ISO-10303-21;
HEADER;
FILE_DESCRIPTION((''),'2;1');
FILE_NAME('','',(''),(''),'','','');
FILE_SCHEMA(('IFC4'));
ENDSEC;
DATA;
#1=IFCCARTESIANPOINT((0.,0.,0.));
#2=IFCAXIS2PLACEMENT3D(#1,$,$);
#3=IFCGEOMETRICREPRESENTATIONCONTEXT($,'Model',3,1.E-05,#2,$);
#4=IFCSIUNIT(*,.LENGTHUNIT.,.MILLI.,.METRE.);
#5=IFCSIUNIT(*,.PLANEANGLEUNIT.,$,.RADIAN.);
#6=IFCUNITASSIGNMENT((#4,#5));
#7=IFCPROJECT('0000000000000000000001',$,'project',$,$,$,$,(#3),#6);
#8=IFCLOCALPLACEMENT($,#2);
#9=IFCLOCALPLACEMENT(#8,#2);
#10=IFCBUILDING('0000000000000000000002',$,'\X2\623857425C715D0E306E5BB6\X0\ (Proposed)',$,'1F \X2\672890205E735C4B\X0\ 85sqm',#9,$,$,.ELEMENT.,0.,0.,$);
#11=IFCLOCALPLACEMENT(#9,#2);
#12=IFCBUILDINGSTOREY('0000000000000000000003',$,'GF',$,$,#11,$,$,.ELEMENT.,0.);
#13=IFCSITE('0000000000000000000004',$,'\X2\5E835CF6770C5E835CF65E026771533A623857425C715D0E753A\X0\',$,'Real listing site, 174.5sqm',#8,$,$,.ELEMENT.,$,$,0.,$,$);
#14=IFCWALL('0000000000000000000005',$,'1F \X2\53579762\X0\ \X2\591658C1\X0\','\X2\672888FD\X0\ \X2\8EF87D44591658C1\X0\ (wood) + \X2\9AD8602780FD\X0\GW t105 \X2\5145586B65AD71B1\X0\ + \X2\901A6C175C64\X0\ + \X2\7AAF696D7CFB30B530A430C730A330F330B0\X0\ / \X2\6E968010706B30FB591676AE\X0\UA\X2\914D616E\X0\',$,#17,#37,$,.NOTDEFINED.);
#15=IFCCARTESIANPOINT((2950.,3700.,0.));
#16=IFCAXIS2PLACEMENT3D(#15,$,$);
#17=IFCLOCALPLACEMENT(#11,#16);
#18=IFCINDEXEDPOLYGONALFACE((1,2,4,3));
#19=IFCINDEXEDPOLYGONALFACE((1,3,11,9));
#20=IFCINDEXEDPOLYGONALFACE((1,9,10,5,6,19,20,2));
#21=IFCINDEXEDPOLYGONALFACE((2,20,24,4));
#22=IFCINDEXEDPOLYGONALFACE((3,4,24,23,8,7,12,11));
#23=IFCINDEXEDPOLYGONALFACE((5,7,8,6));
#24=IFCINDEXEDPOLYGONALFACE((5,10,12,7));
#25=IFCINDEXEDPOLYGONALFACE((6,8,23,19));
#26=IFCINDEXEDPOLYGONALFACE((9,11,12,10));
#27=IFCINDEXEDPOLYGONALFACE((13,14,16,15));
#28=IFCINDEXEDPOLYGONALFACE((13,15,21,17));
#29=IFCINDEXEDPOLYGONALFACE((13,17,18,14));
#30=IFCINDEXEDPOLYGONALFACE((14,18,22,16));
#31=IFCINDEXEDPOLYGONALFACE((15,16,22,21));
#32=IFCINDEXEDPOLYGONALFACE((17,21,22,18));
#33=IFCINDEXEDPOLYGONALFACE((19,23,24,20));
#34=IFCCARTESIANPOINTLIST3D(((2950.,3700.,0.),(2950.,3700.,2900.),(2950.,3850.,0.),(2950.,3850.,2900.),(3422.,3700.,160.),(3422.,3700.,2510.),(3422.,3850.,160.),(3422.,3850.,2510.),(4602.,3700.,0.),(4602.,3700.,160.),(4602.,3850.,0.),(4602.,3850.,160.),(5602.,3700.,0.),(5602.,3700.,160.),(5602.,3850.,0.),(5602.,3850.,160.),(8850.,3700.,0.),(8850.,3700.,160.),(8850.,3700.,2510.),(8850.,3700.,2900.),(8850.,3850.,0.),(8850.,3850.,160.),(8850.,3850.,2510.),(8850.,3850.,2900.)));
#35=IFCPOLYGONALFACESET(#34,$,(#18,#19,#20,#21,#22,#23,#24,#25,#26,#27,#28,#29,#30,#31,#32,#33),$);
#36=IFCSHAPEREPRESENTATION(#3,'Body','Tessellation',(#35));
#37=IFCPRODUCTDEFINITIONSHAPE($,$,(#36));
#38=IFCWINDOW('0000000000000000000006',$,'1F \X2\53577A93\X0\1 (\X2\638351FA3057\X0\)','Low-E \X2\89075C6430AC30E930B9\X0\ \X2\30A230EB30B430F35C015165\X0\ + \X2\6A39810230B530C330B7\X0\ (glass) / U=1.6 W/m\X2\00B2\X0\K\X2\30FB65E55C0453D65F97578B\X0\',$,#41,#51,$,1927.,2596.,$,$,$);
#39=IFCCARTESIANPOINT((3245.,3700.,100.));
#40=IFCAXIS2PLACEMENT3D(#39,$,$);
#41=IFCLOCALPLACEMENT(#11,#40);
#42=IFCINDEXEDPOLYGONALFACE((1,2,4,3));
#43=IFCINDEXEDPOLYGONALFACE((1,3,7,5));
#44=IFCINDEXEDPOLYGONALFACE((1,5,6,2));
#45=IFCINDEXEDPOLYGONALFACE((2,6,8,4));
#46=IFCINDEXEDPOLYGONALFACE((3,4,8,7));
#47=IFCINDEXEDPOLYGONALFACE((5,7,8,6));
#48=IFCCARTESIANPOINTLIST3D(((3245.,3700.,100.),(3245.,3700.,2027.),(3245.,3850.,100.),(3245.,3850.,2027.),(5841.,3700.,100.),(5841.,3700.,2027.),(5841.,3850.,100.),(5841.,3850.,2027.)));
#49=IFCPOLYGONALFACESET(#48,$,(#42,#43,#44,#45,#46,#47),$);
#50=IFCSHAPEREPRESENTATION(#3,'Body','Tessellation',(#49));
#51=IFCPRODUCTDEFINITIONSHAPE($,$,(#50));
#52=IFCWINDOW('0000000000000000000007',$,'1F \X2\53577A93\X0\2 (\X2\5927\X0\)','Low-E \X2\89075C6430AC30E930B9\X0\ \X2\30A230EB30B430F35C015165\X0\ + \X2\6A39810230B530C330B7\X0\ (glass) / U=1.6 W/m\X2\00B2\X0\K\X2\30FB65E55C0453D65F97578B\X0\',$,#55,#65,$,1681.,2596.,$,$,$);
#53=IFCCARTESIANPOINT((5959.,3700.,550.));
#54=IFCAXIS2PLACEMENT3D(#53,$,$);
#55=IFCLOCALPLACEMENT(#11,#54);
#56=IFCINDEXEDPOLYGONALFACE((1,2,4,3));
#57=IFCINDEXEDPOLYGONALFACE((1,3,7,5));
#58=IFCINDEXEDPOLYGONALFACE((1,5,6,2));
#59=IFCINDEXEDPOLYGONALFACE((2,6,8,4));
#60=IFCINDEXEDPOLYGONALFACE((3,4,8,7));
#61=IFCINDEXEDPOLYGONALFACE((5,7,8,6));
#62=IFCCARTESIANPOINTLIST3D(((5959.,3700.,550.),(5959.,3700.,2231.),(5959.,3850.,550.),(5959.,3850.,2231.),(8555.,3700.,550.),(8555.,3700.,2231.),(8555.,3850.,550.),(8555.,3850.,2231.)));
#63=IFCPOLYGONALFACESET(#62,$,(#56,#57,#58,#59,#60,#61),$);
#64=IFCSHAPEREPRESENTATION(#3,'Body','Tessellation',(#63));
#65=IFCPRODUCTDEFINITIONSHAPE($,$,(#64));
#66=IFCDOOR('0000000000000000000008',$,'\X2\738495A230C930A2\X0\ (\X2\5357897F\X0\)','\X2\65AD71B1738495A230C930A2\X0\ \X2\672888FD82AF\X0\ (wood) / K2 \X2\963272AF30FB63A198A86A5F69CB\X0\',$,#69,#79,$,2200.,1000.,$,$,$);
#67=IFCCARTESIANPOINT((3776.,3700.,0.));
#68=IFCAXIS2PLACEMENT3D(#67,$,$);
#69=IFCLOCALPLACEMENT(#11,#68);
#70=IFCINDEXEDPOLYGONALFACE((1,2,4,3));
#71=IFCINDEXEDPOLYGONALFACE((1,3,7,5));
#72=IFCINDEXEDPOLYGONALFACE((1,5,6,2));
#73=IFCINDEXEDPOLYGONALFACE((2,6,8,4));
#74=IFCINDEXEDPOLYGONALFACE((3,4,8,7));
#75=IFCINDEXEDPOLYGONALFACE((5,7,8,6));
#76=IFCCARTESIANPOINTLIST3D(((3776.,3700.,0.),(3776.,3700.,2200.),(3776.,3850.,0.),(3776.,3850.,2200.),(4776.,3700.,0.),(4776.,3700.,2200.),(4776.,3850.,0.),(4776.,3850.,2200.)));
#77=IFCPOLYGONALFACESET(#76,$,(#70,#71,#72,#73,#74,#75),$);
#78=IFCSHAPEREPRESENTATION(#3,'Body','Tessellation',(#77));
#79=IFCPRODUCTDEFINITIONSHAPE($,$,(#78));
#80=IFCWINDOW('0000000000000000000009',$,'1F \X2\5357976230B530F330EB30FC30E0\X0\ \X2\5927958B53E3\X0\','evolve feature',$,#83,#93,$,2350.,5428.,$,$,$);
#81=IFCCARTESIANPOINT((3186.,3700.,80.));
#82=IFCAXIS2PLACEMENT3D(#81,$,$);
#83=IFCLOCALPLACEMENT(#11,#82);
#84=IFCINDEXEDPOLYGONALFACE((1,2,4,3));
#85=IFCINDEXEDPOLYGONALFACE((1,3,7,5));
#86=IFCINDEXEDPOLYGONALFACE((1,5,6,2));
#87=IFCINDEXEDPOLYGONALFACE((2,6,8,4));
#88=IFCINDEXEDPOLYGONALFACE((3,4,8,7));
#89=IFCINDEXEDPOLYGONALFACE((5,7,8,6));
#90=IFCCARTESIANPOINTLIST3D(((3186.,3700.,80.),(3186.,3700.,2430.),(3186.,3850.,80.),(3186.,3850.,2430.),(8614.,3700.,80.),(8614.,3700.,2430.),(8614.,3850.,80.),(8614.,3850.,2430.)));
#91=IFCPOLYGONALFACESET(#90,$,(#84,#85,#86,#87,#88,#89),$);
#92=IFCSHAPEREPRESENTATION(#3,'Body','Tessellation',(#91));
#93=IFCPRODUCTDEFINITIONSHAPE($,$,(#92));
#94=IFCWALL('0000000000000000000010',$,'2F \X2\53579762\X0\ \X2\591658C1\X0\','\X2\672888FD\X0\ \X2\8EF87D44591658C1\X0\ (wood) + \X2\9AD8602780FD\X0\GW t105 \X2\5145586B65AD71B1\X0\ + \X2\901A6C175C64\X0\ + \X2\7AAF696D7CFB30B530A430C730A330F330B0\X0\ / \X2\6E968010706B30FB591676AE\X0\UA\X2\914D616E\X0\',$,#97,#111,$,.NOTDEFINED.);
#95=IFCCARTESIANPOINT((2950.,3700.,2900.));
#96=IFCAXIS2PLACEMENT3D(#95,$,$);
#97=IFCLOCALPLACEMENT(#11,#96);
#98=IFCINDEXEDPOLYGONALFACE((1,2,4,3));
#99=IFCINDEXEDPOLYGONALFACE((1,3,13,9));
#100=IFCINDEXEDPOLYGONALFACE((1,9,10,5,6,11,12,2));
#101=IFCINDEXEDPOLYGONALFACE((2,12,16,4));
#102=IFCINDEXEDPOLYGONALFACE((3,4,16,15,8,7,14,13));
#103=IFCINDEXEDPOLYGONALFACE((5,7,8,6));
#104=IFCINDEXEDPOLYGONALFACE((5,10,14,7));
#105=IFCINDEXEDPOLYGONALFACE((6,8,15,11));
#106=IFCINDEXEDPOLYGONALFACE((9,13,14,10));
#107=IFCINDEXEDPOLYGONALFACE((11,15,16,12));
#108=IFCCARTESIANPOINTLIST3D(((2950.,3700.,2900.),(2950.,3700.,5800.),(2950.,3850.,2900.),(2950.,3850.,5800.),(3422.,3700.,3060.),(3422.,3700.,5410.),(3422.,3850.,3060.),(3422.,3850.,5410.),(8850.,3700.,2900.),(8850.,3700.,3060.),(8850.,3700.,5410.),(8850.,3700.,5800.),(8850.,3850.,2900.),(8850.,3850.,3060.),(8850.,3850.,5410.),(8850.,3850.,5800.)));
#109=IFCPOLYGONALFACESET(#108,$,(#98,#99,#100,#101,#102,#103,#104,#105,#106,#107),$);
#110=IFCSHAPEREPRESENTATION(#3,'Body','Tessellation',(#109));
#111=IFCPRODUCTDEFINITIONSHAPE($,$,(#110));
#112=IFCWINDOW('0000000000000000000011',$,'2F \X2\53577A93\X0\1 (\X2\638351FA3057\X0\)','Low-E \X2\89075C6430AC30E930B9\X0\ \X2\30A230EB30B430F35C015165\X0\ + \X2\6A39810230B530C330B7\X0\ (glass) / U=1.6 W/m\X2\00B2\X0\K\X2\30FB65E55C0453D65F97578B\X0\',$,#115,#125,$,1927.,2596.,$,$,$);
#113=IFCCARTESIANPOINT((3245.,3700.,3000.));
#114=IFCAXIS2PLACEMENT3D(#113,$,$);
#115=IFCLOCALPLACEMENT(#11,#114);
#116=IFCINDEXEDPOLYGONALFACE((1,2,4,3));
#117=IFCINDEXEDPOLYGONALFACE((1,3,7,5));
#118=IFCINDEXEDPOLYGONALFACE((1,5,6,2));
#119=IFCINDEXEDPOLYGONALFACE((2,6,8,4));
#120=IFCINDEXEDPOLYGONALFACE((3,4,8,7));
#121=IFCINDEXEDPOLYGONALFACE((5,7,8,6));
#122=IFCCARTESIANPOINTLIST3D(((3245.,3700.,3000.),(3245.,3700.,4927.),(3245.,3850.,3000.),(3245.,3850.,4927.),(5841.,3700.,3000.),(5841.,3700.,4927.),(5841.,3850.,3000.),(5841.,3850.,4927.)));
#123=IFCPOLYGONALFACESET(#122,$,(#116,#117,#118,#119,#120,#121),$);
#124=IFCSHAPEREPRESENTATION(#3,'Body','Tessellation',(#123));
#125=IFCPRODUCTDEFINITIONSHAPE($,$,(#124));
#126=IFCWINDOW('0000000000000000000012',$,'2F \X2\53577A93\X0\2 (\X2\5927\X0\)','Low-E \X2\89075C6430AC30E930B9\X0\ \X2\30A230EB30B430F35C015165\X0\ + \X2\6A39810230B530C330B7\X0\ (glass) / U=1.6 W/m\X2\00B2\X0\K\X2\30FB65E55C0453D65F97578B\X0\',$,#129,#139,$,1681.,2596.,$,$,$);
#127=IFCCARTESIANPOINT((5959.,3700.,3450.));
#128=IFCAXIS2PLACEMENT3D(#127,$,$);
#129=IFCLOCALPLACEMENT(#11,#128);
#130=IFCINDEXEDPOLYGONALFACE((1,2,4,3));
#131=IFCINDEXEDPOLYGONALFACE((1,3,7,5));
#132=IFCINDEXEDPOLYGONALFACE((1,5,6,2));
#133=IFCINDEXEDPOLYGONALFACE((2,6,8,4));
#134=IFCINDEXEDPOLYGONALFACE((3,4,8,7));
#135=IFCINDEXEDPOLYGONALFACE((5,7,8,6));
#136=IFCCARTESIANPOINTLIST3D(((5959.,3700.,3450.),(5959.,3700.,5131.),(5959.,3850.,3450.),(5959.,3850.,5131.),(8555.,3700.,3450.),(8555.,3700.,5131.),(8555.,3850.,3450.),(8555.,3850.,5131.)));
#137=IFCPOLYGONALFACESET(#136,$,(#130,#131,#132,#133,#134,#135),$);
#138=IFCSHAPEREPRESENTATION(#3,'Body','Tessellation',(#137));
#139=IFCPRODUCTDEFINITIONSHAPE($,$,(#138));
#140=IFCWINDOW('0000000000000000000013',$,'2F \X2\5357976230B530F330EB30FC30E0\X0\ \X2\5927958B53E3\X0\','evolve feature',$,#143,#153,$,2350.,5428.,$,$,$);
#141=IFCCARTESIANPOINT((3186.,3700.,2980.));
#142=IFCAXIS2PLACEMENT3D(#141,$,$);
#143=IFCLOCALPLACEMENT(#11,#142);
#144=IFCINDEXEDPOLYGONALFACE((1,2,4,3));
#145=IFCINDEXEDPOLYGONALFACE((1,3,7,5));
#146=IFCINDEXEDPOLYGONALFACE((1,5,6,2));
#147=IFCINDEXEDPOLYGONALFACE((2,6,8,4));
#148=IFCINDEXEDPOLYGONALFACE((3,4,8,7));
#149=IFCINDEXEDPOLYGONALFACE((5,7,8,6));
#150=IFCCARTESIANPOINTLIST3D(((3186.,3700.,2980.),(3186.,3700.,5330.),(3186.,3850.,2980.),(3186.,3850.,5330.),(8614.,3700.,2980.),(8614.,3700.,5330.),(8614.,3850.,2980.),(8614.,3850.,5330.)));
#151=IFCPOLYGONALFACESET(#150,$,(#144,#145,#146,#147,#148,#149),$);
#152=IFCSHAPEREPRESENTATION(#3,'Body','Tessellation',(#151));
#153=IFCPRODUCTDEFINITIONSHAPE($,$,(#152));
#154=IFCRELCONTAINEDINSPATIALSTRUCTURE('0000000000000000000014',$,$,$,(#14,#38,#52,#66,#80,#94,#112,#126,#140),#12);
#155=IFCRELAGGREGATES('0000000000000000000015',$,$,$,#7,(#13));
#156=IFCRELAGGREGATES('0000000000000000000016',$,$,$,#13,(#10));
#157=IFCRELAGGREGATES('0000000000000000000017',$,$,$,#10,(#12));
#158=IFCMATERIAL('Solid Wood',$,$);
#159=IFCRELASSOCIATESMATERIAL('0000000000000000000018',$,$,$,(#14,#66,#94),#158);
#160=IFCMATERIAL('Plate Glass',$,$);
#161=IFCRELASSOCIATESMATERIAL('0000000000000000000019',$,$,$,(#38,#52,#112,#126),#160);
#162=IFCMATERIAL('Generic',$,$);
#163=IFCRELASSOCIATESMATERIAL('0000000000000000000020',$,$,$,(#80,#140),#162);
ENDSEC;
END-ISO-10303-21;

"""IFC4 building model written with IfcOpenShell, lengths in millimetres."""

from ifc_helpers import new_model, si_unit, frame, frame_2d, origin, place, context, project, spatial, rectangle, extrude, material, element, fill, save


model = new_model("IFC4")

# Units and contexts
model_context = context("Model", 3, precision=1e-05, world=origin())
ifc_project = project(units=[si_unit("LENGTHUNIT", "METRE", prefix="MILLI"), si_unit("PLANEANGLEUNIT", "RADIAN")], contexts=[model_context])

# Site, building, storey
site_placement = place(None, origin())
site = spatial("IfcSite", under=ifc_project, at=site_placement, Name="広島県広島市東区戸坂山崎町", ObjectType="Real listing site, 174.5sqm", CompositionType="ELEMENT", RefElevation=0.0)
building_placement = place(site_placement, origin())
building = spatial("IfcBuilding", under=site, at=building_placement, Name="戸坂山崎の家 (Proposed)", ObjectType="1F 木造平屋 85sqm", CompositionType="ELEMENT", ElevationOfRefHeight=0.0, ElevationOfTerrain=0.0)
storey_placement = place(building_placement, origin())
storey = spatial("IfcBuildingStorey", under=building, at=storey_placement, Name="GF", CompositionType="ELEMENT", Elevation=0.0)

# Shared definitions
ifc_material_1 = material(Name="Solid Wood")
ifc_material_2 = material(Name="Generic")

# Wall, openings, windows, door
wall_1_placement = place(storey_placement, frame((2950.0, 3700.0, 0.0)))
wall_1 = element("IfcWall", 1, at=wall_1_placement, inside=storey, material=ifc_material_1, Name="1F 南面 外壁", Description="木製 軸組外壁 (wood) + 高性能GW t105 充填断熱 + 通気層 + 窯業系サイディング / 準耐火・外皮UA配慮", PredefinedType="NOTDEFINED", context=model_context, shape_type="SweptSolid", body=[
    extrude(rectangle(XDim=5900.0, YDim=150.0, at=frame_2d((2950.0, 75.0))), frame((2950.0, 3700.0, 0.0)), (0.0, 0.0, 1.0), 2900.0),
])
opening_1_placement = place(storey_placement, frame((3245.0, 3700.0, 100.0)))
opening_1 = element("IfcOpeningElement", 2, at=opening_1_placement, cuts=wall_1, PredefinedType="NOTDEFINED", context=model_context, shape_type="SweptSolid", body=[
    extrude(rectangle(XDim=2596.0, YDim=150.0, at=frame_2d((1298.0, 75.0))), frame((3245.0, 3700.0, 100.0)), (0.0, 0.0, 1.0), 1927.0),
])
opening_2_placement = place(storey_placement, frame((5959.0, 3700.0, 550.0)))
opening_2 = element("IfcOpeningElement", 3, at=opening_2_placement, cuts=wall_1, PredefinedType="NOTDEFINED", context=model_context, shape_type="SweptSolid", body=[
    extrude(rectangle(XDim=2596.0, YDim=150.0, at=frame_2d((1298.0, 75.0))), frame((5959.0, 3700.0, 550.0)), (0.0, 0.0, 1.0), 1681.0),
])
opening_3_placement = place(storey_placement, frame((3776.0, 3700.0, 0.0)))
opening_3 = element("IfcOpeningElement", 4, at=opening_3_placement, cuts=wall_1, PredefinedType="NOTDEFINED", context=model_context, shape_type="SweptSolid", body=[
    extrude(rectangle(XDim=1000.0, YDim=150.0, at=frame_2d((500.0, 75.0))), frame((3776.0, 3700.0, 0.0)), (0.0, 0.0, 1.0), 2200.0),
])
opening_4_placement = place(storey_placement, frame((3186.0, 3700.0, 80.0)))
opening_4 = element("IfcOpeningElement", 5, at=opening_4_placement, cuts=wall_1, PredefinedType="NOTDEFINED", context=model_context, shape_type="SweptSolid", body=[
    extrude(rectangle(XDim=5428.0, YDim=150.0, at=frame_2d((2714.0, 75.0))), frame((3186.0, 3700.0, 80.0)), (0.0, 0.0, 1.0), 2350.0),
])
ifc_material_3 = material(Name="Plate Glass")
window_1_placement = place(storey_placement, frame((3245.0, 3700.0, 100.0)))
window_1 = element("IfcWindow", 6, at=window_1_placement, inside=storey, material=ifc_material_3, Name="1F 南窓1 (掃出し)", Description="Low-E 複層ガラス アルゴン封入 + 樹脂サッシ (glass) / U=1.6 W/m²K・日射取得型", OverallHeight=1927.0, OverallWidth=2596.0, context=model_context, shape_type="SweptSolid", body=[
    extrude(rectangle(XDim=2596.0, YDim=150.0, at=frame_2d((1298.0, 75.0))), frame((3245.0, 3700.0, 100.0)), (0.0, 0.0, 1.0), 1927.0),
])
fill(opening_1, window_1)
window_2_placement = place(storey_placement, frame((5959.0, 3700.0, 550.0)))
window_2 = element("IfcWindow", 7, at=window_2_placement, inside=storey, material=ifc_material_3, Name="1F 南窓2 (大)", Description="Low-E 複層ガラス アルゴン封入 + 樹脂サッシ (glass) / U=1.6 W/m²K・日射取得型", OverallHeight=1681.0, OverallWidth=2596.0, context=model_context, shape_type="SweptSolid", body=[
    extrude(rectangle(XDim=2596.0, YDim=150.0, at=frame_2d((1298.0, 75.0))), frame((5959.0, 3700.0, 550.0)), (0.0, 0.0, 1.0), 1681.0),
])
fill(opening_2, window_2)
door_placement = place(storey_placement, frame((3776.0, 3700.0, 0.0)))
door = element("IfcDoor", 8, at=door_placement, inside=storey, material=ifc_material_1, Name="玄関ドア (南西)", Description="断熱玄関ドア 木製芯 (wood) / K2 防犯・採風機構", OverallHeight=2200.0, OverallWidth=1000.0, context=model_context, shape_type="SweptSolid", body=[
    extrude(rectangle(XDim=1000.0, YDim=150.0, at=frame_2d((500.0, 75.0))), frame((3776.0, 3700.0, 0.0)), (0.0, 0.0, 1.0), 2200.0),
])
fill(opening_3, door)
window_3_placement = place(storey_placement, frame((3186.0, 3700.0, 80.0)))
window_3 = element("IfcWindow", 9, at=window_3_placement, inside=storey, material=ifc_material_2, Name="1F 南面サンルーム 大開口", Description="evolve feature", OverallHeight=2350.0, OverallWidth=5428.0, context=model_context, shape_type="SweptSolid", body=[
    extrude(rectangle(XDim=5428.0, YDim=150.0, at=frame_2d((2714.0, 75.0))), frame((3186.0, 3700.0, 80.0)), (0.0, 0.0, 1.0), 2350.0),
])
fill(opening_4, window_3)

# Wall, openings, windows
wall_2_placement = place(storey_placement, frame((2950.0, 3700.0, 2900.0)))
wall_2 = element("IfcWall", 10, at=wall_2_placement, inside=storey, material=ifc_material_1, Name="2F 南面 外壁", Description="木製 軸組外壁 (wood) + 高性能GW t105 充填断熱 + 通気層 + 窯業系サイディング / 準耐火・外皮UA配慮", PredefinedType="NOTDEFINED", context=model_context, shape_type="SweptSolid", body=[
    extrude(rectangle(XDim=5900.0, YDim=150.0, at=frame_2d((2950.0, 75.0))), frame((2950.0, 3700.0, 2900.0)), (0.0, 0.0, 1.0), 2900.0),
])
opening_5_placement = place(storey_placement, frame((3245.0, 3700.0, 3000.0)))
opening_5 = element("IfcOpeningElement", 11, at=opening_5_placement, cuts=wall_2, PredefinedType="NOTDEFINED", context=model_context, shape_type="SweptSolid", body=[
    extrude(rectangle(XDim=2596.0, YDim=150.0, at=frame_2d((1298.0, 75.0))), frame((3245.0, 3700.0, 3000.0)), (0.0, 0.0, 1.0), 1927.0),
])
opening_6_placement = place(storey_placement, frame((5959.0, 3700.0, 3450.0)))
opening_6 = element("IfcOpeningElement", 12, at=opening_6_placement, cuts=wall_2, PredefinedType="NOTDEFINED", context=model_context, shape_type="SweptSolid", body=[
    extrude(rectangle(XDim=2596.0, YDim=150.0, at=frame_2d((1298.0, 75.0))), frame((5959.0, 3700.0, 3450.0)), (0.0, 0.0, 1.0), 1681.0),
])
opening_7_placement = place(storey_placement, frame((3186.0, 3700.0, 2980.0)))
opening_7 = element("IfcOpeningElement", 13, at=opening_7_placement, cuts=wall_2, PredefinedType="NOTDEFINED", context=model_context, shape_type="SweptSolid", body=[
    extrude(rectangle(XDim=5428.0, YDim=150.0, at=frame_2d((2714.0, 75.0))), frame((3186.0, 3700.0, 2980.0)), (0.0, 0.0, 1.0), 2350.0),
])
window_4_placement = place(storey_placement, frame((3245.0, 3700.0, 3000.0)))
window_4 = element("IfcWindow", 14, at=window_4_placement, inside=storey, material=ifc_material_3, Name="2F 南窓1 (掃出し)", Description="Low-E 複層ガラス アルゴン封入 + 樹脂サッシ (glass) / U=1.6 W/m²K・日射取得型", OverallHeight=1927.0, OverallWidth=2596.0, context=model_context, shape_type="SweptSolid", body=[
    extrude(rectangle(XDim=2596.0, YDim=150.0, at=frame_2d((1298.0, 75.0))), frame((3245.0, 3700.0, 3000.0)), (0.0, 0.0, 1.0), 1927.0),
])
fill(opening_5, window_4)
window_5_placement = place(storey_placement, frame((5959.0, 3700.0, 3450.0)))
window_5 = element("IfcWindow", 15, at=window_5_placement, inside=storey, material=ifc_material_3, Name="2F 南窓2 (大)", Description="Low-E 複層ガラス アルゴン封入 + 樹脂サッシ (glass) / U=1.6 W/m²K・日射取得型", OverallHeight=1681.0, OverallWidth=2596.0, context=model_context, shape_type="SweptSolid", body=[
    extrude(rectangle(XDim=2596.0, YDim=150.0, at=frame_2d((1298.0, 75.0))), frame((5959.0, 3700.0, 3450.0)), (0.0, 0.0, 1.0), 1681.0),
])
fill(opening_6, window_5)
window_6_placement = place(storey_placement, frame((3186.0, 3700.0, 2980.0)))
window_6 = element("IfcWindow", 16, at=window_6_placement, inside=storey, material=ifc_material_2, Name="2F 南面サンルーム 大開口", Description="evolve feature", OverallHeight=2350.0, OverallWidth=5428.0, context=model_context, shape_type="SweptSolid", body=[
    extrude(rectangle(XDim=5428.0, YDim=150.0, at=frame_2d((2714.0, 75.0))), frame((3186.0, 3700.0, 2980.0)), (0.0, 0.0, 1.0), 2350.0),
])
fill(opening_7, window_6)

save(model, "model.ifc")
